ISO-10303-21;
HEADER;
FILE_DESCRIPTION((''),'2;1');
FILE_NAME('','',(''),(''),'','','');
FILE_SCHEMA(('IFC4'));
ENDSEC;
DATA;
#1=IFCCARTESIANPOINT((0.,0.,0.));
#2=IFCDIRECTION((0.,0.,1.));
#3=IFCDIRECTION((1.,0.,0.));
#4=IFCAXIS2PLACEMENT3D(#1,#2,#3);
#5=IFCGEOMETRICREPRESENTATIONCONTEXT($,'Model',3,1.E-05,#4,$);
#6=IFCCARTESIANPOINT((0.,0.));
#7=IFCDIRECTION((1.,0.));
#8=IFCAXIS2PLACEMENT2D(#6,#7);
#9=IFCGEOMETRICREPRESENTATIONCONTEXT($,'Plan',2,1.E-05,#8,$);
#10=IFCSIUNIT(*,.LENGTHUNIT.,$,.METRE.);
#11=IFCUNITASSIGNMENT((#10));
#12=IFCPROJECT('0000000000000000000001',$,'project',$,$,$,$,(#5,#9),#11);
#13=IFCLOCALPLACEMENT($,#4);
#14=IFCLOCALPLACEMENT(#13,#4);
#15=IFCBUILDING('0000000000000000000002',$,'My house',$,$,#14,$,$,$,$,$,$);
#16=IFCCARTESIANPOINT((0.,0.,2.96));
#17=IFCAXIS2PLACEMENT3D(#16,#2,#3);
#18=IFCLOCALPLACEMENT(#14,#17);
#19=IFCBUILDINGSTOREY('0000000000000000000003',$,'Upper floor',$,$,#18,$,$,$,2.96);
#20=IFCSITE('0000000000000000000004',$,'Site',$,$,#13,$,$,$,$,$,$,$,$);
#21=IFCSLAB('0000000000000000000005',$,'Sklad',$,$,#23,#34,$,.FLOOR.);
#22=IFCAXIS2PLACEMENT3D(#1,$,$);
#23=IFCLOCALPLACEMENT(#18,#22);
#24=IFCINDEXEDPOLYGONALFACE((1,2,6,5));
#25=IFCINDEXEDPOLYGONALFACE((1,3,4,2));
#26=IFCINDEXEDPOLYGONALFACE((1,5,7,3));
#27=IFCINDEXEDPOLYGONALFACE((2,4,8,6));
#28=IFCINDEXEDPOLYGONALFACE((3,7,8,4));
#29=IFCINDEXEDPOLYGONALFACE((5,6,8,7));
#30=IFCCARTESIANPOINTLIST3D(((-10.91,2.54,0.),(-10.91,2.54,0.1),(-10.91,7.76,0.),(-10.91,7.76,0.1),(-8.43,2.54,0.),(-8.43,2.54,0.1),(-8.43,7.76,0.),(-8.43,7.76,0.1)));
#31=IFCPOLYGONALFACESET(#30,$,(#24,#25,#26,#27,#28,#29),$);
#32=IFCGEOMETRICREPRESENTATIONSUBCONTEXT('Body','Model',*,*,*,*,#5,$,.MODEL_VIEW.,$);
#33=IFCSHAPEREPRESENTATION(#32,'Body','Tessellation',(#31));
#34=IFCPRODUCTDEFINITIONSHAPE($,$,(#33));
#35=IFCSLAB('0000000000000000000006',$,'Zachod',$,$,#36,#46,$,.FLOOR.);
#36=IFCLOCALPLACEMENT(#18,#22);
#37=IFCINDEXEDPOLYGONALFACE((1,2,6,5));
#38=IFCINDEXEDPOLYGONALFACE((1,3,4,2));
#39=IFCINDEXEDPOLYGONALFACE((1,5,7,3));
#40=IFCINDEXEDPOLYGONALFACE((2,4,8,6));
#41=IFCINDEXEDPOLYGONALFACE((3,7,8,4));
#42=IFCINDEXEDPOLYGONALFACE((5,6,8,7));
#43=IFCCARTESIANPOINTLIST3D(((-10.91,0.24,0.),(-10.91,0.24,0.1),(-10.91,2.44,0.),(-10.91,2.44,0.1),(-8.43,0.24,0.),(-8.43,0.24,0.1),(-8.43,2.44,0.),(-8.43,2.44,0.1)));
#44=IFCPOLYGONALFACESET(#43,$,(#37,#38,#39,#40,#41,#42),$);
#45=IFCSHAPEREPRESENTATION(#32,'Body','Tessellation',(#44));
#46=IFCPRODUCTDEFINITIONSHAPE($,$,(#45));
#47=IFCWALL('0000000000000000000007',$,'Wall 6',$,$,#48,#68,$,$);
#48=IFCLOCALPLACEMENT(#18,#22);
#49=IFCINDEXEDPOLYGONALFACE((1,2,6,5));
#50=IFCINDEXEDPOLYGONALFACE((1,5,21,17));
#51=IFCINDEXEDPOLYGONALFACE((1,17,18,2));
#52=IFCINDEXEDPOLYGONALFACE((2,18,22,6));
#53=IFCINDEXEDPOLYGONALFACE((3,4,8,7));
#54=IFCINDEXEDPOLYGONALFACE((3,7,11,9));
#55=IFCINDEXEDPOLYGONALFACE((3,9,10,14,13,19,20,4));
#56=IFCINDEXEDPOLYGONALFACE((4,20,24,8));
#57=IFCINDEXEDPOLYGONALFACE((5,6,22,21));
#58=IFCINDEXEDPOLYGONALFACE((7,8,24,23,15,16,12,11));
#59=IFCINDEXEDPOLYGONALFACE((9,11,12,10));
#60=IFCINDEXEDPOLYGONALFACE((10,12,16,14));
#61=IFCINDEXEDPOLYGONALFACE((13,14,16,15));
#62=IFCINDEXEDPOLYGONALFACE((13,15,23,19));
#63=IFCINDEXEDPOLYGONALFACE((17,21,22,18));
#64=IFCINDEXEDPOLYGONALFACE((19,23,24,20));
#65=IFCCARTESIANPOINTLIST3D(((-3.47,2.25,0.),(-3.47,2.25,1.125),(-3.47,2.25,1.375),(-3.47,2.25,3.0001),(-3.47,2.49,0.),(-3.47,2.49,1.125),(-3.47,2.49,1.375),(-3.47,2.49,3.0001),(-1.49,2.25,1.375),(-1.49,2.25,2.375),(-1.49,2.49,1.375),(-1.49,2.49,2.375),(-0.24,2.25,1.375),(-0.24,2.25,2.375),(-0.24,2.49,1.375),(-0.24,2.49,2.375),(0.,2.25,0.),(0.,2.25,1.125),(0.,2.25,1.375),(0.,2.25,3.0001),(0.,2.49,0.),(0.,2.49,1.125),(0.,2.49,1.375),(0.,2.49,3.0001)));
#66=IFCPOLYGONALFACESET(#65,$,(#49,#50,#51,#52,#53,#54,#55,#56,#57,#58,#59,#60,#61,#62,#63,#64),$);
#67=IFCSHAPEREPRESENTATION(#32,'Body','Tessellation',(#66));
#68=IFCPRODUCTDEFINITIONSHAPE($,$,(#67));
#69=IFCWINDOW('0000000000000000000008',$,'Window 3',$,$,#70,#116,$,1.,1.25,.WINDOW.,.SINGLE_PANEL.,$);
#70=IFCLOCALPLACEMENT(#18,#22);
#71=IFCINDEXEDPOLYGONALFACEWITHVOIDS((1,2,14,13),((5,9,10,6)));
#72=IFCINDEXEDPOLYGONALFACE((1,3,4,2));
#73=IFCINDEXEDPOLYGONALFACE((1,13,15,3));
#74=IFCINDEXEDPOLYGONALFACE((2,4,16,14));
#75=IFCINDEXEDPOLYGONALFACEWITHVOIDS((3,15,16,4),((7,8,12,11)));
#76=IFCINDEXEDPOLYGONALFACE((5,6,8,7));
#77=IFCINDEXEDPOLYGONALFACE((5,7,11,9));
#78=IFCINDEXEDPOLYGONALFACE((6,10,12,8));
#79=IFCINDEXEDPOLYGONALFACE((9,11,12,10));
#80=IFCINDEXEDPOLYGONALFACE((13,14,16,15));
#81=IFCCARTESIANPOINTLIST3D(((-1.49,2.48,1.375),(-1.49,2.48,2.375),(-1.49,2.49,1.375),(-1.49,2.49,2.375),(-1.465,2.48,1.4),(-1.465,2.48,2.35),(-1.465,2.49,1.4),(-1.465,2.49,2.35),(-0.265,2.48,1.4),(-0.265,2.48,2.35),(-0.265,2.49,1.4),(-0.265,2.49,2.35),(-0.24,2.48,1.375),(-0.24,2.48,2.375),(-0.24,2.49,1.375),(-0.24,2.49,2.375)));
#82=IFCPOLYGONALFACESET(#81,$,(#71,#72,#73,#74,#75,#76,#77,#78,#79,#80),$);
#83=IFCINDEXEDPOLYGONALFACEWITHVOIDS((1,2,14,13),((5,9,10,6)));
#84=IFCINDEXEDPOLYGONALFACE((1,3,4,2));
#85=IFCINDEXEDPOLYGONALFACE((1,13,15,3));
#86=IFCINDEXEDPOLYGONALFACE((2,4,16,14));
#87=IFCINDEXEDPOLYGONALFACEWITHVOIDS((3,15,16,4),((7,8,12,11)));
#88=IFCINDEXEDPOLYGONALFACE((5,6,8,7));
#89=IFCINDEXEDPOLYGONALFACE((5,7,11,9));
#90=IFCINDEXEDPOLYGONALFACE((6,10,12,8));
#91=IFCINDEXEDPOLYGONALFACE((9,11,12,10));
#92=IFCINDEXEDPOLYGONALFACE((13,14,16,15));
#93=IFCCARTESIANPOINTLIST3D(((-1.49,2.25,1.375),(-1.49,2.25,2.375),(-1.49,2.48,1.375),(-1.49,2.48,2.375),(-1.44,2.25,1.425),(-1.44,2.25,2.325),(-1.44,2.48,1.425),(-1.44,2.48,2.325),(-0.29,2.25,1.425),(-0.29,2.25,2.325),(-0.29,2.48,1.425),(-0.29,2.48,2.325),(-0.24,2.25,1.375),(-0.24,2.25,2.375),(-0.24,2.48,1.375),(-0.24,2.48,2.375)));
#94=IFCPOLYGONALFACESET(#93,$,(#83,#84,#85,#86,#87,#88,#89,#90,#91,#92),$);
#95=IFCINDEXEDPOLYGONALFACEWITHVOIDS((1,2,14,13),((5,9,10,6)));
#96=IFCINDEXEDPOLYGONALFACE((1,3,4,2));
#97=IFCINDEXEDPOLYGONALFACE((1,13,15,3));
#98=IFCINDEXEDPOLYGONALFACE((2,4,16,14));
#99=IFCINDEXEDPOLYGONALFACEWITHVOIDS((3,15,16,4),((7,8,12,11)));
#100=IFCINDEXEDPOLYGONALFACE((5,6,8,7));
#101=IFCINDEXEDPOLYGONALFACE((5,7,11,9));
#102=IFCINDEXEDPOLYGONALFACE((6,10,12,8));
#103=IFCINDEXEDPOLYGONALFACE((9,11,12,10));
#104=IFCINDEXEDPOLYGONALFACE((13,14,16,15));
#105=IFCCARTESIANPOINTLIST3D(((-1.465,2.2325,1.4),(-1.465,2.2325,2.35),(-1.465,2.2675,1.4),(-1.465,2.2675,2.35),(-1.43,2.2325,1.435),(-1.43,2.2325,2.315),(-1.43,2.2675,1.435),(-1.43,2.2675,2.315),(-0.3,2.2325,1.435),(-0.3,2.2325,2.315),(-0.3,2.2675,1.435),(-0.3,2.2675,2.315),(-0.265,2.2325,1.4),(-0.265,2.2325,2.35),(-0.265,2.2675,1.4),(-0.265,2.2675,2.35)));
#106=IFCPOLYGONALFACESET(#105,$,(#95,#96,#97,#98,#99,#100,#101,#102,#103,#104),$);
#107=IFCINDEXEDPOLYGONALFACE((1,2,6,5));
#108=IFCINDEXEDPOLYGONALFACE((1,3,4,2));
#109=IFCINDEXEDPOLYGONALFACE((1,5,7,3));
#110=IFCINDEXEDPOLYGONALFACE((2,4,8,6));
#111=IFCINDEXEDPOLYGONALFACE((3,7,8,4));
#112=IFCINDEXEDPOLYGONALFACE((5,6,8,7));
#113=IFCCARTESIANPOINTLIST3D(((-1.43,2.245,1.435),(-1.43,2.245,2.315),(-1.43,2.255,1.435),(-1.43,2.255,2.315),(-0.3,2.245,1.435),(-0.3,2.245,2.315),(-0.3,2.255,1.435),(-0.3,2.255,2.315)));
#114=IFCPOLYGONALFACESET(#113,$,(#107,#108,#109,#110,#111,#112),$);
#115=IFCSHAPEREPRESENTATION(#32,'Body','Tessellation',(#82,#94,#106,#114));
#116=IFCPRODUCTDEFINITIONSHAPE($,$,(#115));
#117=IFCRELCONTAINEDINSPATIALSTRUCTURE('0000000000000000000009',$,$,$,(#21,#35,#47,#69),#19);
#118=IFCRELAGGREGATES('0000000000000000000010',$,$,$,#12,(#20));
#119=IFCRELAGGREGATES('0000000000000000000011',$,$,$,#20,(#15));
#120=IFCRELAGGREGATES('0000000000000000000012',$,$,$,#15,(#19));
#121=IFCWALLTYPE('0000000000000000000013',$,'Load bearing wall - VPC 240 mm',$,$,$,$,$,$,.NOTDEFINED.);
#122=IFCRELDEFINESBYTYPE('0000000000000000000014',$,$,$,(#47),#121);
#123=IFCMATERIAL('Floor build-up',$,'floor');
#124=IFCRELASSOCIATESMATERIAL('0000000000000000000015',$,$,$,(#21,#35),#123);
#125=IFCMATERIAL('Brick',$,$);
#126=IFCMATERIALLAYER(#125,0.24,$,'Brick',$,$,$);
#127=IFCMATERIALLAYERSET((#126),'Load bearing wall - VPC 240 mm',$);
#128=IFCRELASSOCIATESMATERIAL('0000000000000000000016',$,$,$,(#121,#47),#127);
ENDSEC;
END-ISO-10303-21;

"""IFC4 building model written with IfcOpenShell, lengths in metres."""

from ifc_helpers import new_model, entity, si_unit, frame, origin_with_axes, origin_2d_with_axis, place, context, subcontext, project, spatial, line, indexed_curve, outline, extrude, boolean, clip, halfspace, shape, source, transform, mapped, material, layer, layer_set, layer_usage, type_object, element, fill, save


model = new_model("IFC4")

# Units and contexts
model_context = context("Model", 3, precision=1e-05, world=origin_with_axes())
plan_context = context("Plan", 2, precision=1e-05, world=origin_2d_with_axis())
body_context_1 = subcontext(model_context, "Body", "Model", "MODEL_VIEW")
body_context_2 = subcontext(plan_context, "Body", "Plan", "PLAN_VIEW")
ifc_project = project(units=[si_unit("LENGTHUNIT", "METRE")], contexts=[model_context, plan_context])

# Site, building, storey
site_placement = place(None, origin_with_axes())
site = spatial("IfcSite", under=ifc_project, at=site_placement, Name="Site")
building_placement = place(site_placement, origin_with_axes())
building = spatial("IfcBuilding", under=site, at=building_placement, Name="My house")
storey_placement = place(building_placement, frame((0.0, 0.0, 2.96), z_axis=(0.0, 0.0, 1.0), x_axis=(1.0, 0.0, 0.0)))
storey = spatial("IfcBuildingStorey", under=building, at=storey_placement, Name="Upper floor", Elevation=2.96)

# Slabs
ifc_material_1 = material(Name="Floor build-up", Category="floor")
shared_shape_1 = source(origin_with_axes(), body_context_1, "Body", "SweptSolid", [
    extrude(outline(indexed_curve([(8.43, 2.54), (10.91, 2.54), (10.91, 7.76), (8.43, 7.76)])), None, (0.0, 0.0, 1.0), 0.1),
])
slab_1_placement = place(storey_placement, origin_with_axes())
element("IfcSlab", 1, at=slab_1_placement, inside=storey, material=ifc_material_1, Name="Sklad", PredefinedType="FLOOR", context=body_context_1, shape_type="MappedRepresentation", body=[
    mapped(shared_shape_1, transform((0.0, 0.0, 0.0), x_axis=(-1.0, 0.0, 0.0), y_axis=(0.0, 1.0, 0.0), z_axis=(0.0, 0.0, 1.0), scale=1.0)),
])
shared_shape_2 = source(origin_with_axes(), body_context_1, "Body", "SweptSolid", [
    extrude(outline(indexed_curve([(8.43, 2.44), (10.91, 2.44), (10.91, 0.24), (8.43, 0.24)])), None, (0.0, 0.0, 1.0), 0.1),
])
slab_2_placement = place(storey_placement, origin_with_axes())
element("IfcSlab", 2, at=slab_2_placement, inside=storey, material=ifc_material_1, Name="Zachod", PredefinedType="FLOOR", context=body_context_1, shape_type="MappedRepresentation", body=[
    mapped(shared_shape_2, transform((0.0, 0.0, 0.0), x_axis=(-1.0, 0.0, 0.0), y_axis=(0.0, 1.0, 0.0), z_axis=(0.0, 0.0, 1.0), scale=1.0)),
])

# Wall, opening, window
ifc_material_2 = material(Name="Brick")
ifc_layer = layer(ifc_material_2, 0.24, Name="Brick")
ifc_layer_set = layer_set([ifc_layer], Name="Load bearing wall - VPC 240 mm")
ifc_layer_usage = layer_usage(ifc_layer_set, "AXIS2", "NEGATIVE", 0.24)
wall_type = type_object("IfcWallType", Name="Load bearing wall - VPC 240 mm", PredefinedType="NOTDEFINED", material=ifc_layer_set)
shared_shape_3 = source(origin_with_axes(), body_context_1, "Body", "CSG", [
    boolean("DIFFERENCE", clip(clip(clip(extrude(outline(indexed_curve([(0.0, 0.0), (0.0, 0.24), (3.47, 0.24), (3.47, 0.0), (0.0, 0.0)], self_intersect=False)), origin_with_axes(), (0.0, 0.0, 1.0), 3.0001), halfspace(frame((0.0, 0.6003, 3.4595), z_axis=(0.0, -0.585512, 0.810664), x_axis=(-1.0, 0.0, 0.0)), False)), halfspace(frame((0.0, 2.8997, 3.4595), z_axis=(0.0, 0.585512, 0.810664), x_axis=(1.0, 0.0, 0.0)), False)), halfspace(frame((0.0, 0.571, 3.22), z_axis=(0.0, 0.0, 1.0), x_axis=(-1.0, 0.0, 0.0)), False)), extrude(outline(indexed_curve([(0.0, 0.0), (3.49, 0.0), (3.49, 0.24), (0.0, 0.24)], segments=[line(1, 2, 3, 4, 1)])), frame((-0.01, 0.0, 1.125), z_axis=(0.0, 0.0, 1.0), x_axis=(1.0, 0.0, 0.0)), (0.0, 0.0, 1.0), 0.25)),
])
wall_placement = place(storey_placement, frame((0.0, 2.25, 0.0), z_axis=(0.0, 0.0, 1.0), x_axis=(1.0, 0.0, 0.0)))
wall = element("IfcWall", 3, at=wall_placement, inside=storey, type_object=wall_type, material=ifc_layer_usage, Name="Wall 6", context=body_context_1, shape_type="MappedRepresentation", body=[
    mapped(shared_shape_3, transform((0.0, 0.0, 0.0), x_axis=(-1.0, 0.0, 0.0), y_axis=(0.0, 1.0, 0.0), z_axis=(0.0, 0.0, 1.0), scale=1.0)),
])
shared_shape_4 = source(origin_with_axes(), body_context_1, "Body", "SweptSolid", [
    extrude(outline(indexed_curve([(0.0, 0.0), (0.0, 0.34), (1.25, 0.34), (1.25, 0.0), (0.0, 0.0)], self_intersect=False)), frame((0.0, -0.05, 0.0), z_axis=(0.0, 0.0, 1.0), x_axis=(1.0, 0.0, 0.0)), (0.0, 0.0, 1.0), 1.0),
])
opening_placement = place(wall_placement, frame((-0.24, 0.0, 1.375), z_axis=(0.0, 0.0, 1.0), x_axis=(1.0, 0.0, 0.0)))
opening = element("IfcOpeningElement", 4, at=opening_placement, cuts=wall, PredefinedType="OPENING", context=body_context_1, shape_type="MappedRepresentation", body=[
    mapped(shared_shape_4, transform((0.0, 0.0, 0.0), x_axis=(-1.0, 0.0, 0.0), y_axis=(0.0, 1.0, 0.0), z_axis=(0.0, 0.0, 1.0), scale=1.0)),
])
shared_shape_5 = source(origin_with_axes(), body_context_1, "Body", "SweptSolid", [
    extrude(outline(indexed_curve([(0.0, 0.0), (1.25, 0.0), (1.25, 1.0), (0.0, 1.0)], segments=[line(1, 2, 3, 4, 1)]), holes=[indexed_curve([(0.025, 0.025), (1.225, 0.025), (1.225, 0.975), (0.025, 0.975)], segments=[line(1, 2, 3, 4, 1)])]), frame((0.0, 0.23, 0.0), z_axis=(0.0, -1.0, 0.0), x_axis=(1.0, 0.0, 0.0)), (0.0, 0.0, -1.0), 0.01),
    extrude(outline(indexed_curve([(0.0, 0.0), (1.25, 0.0), (1.25, 1.0), (0.0, 1.0)], segments=[line(1, 2, 3, 4, 1)]), holes=[indexed_curve([(0.05, 0.05), (1.2, 0.05), (1.2, 0.95), (0.05, 0.95)], segments=[line(1, 2, 3, 4, 1)])]), frame((0.0, 0.0, 0.0), z_axis=(0.0, -1.0, 0.0), x_axis=(1.0, 0.0, 0.0)), (0.0, 0.0, -1.0), 0.23),
    extrude(outline(indexed_curve([(0.0, 0.0), (1.2, 0.0), (1.2, 0.95), (0.0, 0.95)], segments=[line(1, 2, 3, 4, 1)]), holes=[indexed_curve([(0.035, 0.035), (1.165, 0.035), (1.165, 0.915), (0.035, 0.915)], segments=[line(1, 2, 3, 4, 1)])]), frame((0.025, -0.0175, 0.025), z_axis=(0.0, -1.0, 0.0), x_axis=(1.0, 0.0, 0.0)), (0.0, 0.0, -1.0), 0.035),
    extrude(outline(indexed_curve([(0.035, 0.035), (1.165, 0.035), (1.165, 0.915), (0.035, 0.915)], segments=[line(1, 2, 3, 4, 1)])), frame((0.025, -0.005, 0.025), z_axis=(0.0, -1.0, 0.0), x_axis=(1.0, 0.0, 0.0)), (0.0, 0.0, -1.0), 0.01),
])
shared_shape_6 = source(origin_with_axes(), body_context_2, "Body", "Curve2D", [
    entity("IfcIndexedPolyCurve", entity("IfcCartesianPointList2D", [[0.05, 0.0], [1.2, 0.0]])),
    entity("IfcIndexedPolyCurve", entity("IfcCartesianPointList2D", [[0.0, 0.24], [0.025, 0.24], [0.025, 0.23], [0.05, 0.23], [0.05, 0.0], [0.0, 0.0]]), [entity("IfcLineIndex", [1, 2, 3, 4, 5, 6, 1])]),
    entity("IfcIndexedPolyCurve", entity("IfcCartesianPointList2D", [[1.25, 0.24], [1.225, 0.24], [1.225, 0.23], [1.2, 0.23], [1.2, 0.0], [1.25, 0.0]]), [entity("IfcLineIndex", [1, 2, 3, 4, 5, 6, 1])]),
    entity("IfcIndexedPolyCurve", entity("IfcCartesianPointList2D", [[0.025, -0.0175], [0.06, -0.0175], [0.06, 0.0175], [0.025, 0.0175]]), [entity("IfcLineIndex", [1, 2, 3, 4, 1])]),
    entity("IfcIndexedPolyCurve", entity("IfcCartesianPointList2D", [[1.225, -0.0175], [1.19, -0.0175], [1.19, 0.0175], [1.225, 0.0175]]), [entity("IfcLineIndex", [1, 2, 3, 4, 1])]),
    entity("IfcIndexedPolyCurve", entity("IfcCartesianPointList2D", [[0.06, -0.0175], [1.19, -0.0175]])),
    entity("IfcIndexedPolyCurve", entity("IfcCartesianPointList2D", [[0.06, 0.0175], [1.19, 0.0175]])),
    entity("IfcIndexedPolyCurve", entity("IfcCartesianPointList2D", [[0.06, 0.0], [1.19, 0.0]])),
])
window_placement = place(opening_placement, origin_with_axes())
window = element("IfcWindow", 5, at=window_placement, inside=storey, Name="Window 3", OverallHeight=1.0, OverallWidth=1.25, PartitioningType="SINGLE_PANEL", PredefinedType="WINDOW", shapes=[
    shape(body_context_1, "Body", "MappedRepresentation", [mapped(shared_shape_5, transform((0.0, 0.0, 0.0), x_axis=(-1.0, 0.0, 0.0), y_axis=(0.0, 1.0, 0.0), z_axis=(0.0, 0.0, 1.0), scale=1.0))]),
    shape(body_context_2, "Body", "MappedRepresentation", [mapped(shared_shape_6, transform((0.0, 0.0, 0.0), x_axis=(-1.0, 0.0, 0.0), y_axis=(0.0, 1.0, 0.0), z_axis=(0.0, 0.0, 1.0), scale=1.0))]),
])
fill(opening, window)

save(model, "model.ifc")
